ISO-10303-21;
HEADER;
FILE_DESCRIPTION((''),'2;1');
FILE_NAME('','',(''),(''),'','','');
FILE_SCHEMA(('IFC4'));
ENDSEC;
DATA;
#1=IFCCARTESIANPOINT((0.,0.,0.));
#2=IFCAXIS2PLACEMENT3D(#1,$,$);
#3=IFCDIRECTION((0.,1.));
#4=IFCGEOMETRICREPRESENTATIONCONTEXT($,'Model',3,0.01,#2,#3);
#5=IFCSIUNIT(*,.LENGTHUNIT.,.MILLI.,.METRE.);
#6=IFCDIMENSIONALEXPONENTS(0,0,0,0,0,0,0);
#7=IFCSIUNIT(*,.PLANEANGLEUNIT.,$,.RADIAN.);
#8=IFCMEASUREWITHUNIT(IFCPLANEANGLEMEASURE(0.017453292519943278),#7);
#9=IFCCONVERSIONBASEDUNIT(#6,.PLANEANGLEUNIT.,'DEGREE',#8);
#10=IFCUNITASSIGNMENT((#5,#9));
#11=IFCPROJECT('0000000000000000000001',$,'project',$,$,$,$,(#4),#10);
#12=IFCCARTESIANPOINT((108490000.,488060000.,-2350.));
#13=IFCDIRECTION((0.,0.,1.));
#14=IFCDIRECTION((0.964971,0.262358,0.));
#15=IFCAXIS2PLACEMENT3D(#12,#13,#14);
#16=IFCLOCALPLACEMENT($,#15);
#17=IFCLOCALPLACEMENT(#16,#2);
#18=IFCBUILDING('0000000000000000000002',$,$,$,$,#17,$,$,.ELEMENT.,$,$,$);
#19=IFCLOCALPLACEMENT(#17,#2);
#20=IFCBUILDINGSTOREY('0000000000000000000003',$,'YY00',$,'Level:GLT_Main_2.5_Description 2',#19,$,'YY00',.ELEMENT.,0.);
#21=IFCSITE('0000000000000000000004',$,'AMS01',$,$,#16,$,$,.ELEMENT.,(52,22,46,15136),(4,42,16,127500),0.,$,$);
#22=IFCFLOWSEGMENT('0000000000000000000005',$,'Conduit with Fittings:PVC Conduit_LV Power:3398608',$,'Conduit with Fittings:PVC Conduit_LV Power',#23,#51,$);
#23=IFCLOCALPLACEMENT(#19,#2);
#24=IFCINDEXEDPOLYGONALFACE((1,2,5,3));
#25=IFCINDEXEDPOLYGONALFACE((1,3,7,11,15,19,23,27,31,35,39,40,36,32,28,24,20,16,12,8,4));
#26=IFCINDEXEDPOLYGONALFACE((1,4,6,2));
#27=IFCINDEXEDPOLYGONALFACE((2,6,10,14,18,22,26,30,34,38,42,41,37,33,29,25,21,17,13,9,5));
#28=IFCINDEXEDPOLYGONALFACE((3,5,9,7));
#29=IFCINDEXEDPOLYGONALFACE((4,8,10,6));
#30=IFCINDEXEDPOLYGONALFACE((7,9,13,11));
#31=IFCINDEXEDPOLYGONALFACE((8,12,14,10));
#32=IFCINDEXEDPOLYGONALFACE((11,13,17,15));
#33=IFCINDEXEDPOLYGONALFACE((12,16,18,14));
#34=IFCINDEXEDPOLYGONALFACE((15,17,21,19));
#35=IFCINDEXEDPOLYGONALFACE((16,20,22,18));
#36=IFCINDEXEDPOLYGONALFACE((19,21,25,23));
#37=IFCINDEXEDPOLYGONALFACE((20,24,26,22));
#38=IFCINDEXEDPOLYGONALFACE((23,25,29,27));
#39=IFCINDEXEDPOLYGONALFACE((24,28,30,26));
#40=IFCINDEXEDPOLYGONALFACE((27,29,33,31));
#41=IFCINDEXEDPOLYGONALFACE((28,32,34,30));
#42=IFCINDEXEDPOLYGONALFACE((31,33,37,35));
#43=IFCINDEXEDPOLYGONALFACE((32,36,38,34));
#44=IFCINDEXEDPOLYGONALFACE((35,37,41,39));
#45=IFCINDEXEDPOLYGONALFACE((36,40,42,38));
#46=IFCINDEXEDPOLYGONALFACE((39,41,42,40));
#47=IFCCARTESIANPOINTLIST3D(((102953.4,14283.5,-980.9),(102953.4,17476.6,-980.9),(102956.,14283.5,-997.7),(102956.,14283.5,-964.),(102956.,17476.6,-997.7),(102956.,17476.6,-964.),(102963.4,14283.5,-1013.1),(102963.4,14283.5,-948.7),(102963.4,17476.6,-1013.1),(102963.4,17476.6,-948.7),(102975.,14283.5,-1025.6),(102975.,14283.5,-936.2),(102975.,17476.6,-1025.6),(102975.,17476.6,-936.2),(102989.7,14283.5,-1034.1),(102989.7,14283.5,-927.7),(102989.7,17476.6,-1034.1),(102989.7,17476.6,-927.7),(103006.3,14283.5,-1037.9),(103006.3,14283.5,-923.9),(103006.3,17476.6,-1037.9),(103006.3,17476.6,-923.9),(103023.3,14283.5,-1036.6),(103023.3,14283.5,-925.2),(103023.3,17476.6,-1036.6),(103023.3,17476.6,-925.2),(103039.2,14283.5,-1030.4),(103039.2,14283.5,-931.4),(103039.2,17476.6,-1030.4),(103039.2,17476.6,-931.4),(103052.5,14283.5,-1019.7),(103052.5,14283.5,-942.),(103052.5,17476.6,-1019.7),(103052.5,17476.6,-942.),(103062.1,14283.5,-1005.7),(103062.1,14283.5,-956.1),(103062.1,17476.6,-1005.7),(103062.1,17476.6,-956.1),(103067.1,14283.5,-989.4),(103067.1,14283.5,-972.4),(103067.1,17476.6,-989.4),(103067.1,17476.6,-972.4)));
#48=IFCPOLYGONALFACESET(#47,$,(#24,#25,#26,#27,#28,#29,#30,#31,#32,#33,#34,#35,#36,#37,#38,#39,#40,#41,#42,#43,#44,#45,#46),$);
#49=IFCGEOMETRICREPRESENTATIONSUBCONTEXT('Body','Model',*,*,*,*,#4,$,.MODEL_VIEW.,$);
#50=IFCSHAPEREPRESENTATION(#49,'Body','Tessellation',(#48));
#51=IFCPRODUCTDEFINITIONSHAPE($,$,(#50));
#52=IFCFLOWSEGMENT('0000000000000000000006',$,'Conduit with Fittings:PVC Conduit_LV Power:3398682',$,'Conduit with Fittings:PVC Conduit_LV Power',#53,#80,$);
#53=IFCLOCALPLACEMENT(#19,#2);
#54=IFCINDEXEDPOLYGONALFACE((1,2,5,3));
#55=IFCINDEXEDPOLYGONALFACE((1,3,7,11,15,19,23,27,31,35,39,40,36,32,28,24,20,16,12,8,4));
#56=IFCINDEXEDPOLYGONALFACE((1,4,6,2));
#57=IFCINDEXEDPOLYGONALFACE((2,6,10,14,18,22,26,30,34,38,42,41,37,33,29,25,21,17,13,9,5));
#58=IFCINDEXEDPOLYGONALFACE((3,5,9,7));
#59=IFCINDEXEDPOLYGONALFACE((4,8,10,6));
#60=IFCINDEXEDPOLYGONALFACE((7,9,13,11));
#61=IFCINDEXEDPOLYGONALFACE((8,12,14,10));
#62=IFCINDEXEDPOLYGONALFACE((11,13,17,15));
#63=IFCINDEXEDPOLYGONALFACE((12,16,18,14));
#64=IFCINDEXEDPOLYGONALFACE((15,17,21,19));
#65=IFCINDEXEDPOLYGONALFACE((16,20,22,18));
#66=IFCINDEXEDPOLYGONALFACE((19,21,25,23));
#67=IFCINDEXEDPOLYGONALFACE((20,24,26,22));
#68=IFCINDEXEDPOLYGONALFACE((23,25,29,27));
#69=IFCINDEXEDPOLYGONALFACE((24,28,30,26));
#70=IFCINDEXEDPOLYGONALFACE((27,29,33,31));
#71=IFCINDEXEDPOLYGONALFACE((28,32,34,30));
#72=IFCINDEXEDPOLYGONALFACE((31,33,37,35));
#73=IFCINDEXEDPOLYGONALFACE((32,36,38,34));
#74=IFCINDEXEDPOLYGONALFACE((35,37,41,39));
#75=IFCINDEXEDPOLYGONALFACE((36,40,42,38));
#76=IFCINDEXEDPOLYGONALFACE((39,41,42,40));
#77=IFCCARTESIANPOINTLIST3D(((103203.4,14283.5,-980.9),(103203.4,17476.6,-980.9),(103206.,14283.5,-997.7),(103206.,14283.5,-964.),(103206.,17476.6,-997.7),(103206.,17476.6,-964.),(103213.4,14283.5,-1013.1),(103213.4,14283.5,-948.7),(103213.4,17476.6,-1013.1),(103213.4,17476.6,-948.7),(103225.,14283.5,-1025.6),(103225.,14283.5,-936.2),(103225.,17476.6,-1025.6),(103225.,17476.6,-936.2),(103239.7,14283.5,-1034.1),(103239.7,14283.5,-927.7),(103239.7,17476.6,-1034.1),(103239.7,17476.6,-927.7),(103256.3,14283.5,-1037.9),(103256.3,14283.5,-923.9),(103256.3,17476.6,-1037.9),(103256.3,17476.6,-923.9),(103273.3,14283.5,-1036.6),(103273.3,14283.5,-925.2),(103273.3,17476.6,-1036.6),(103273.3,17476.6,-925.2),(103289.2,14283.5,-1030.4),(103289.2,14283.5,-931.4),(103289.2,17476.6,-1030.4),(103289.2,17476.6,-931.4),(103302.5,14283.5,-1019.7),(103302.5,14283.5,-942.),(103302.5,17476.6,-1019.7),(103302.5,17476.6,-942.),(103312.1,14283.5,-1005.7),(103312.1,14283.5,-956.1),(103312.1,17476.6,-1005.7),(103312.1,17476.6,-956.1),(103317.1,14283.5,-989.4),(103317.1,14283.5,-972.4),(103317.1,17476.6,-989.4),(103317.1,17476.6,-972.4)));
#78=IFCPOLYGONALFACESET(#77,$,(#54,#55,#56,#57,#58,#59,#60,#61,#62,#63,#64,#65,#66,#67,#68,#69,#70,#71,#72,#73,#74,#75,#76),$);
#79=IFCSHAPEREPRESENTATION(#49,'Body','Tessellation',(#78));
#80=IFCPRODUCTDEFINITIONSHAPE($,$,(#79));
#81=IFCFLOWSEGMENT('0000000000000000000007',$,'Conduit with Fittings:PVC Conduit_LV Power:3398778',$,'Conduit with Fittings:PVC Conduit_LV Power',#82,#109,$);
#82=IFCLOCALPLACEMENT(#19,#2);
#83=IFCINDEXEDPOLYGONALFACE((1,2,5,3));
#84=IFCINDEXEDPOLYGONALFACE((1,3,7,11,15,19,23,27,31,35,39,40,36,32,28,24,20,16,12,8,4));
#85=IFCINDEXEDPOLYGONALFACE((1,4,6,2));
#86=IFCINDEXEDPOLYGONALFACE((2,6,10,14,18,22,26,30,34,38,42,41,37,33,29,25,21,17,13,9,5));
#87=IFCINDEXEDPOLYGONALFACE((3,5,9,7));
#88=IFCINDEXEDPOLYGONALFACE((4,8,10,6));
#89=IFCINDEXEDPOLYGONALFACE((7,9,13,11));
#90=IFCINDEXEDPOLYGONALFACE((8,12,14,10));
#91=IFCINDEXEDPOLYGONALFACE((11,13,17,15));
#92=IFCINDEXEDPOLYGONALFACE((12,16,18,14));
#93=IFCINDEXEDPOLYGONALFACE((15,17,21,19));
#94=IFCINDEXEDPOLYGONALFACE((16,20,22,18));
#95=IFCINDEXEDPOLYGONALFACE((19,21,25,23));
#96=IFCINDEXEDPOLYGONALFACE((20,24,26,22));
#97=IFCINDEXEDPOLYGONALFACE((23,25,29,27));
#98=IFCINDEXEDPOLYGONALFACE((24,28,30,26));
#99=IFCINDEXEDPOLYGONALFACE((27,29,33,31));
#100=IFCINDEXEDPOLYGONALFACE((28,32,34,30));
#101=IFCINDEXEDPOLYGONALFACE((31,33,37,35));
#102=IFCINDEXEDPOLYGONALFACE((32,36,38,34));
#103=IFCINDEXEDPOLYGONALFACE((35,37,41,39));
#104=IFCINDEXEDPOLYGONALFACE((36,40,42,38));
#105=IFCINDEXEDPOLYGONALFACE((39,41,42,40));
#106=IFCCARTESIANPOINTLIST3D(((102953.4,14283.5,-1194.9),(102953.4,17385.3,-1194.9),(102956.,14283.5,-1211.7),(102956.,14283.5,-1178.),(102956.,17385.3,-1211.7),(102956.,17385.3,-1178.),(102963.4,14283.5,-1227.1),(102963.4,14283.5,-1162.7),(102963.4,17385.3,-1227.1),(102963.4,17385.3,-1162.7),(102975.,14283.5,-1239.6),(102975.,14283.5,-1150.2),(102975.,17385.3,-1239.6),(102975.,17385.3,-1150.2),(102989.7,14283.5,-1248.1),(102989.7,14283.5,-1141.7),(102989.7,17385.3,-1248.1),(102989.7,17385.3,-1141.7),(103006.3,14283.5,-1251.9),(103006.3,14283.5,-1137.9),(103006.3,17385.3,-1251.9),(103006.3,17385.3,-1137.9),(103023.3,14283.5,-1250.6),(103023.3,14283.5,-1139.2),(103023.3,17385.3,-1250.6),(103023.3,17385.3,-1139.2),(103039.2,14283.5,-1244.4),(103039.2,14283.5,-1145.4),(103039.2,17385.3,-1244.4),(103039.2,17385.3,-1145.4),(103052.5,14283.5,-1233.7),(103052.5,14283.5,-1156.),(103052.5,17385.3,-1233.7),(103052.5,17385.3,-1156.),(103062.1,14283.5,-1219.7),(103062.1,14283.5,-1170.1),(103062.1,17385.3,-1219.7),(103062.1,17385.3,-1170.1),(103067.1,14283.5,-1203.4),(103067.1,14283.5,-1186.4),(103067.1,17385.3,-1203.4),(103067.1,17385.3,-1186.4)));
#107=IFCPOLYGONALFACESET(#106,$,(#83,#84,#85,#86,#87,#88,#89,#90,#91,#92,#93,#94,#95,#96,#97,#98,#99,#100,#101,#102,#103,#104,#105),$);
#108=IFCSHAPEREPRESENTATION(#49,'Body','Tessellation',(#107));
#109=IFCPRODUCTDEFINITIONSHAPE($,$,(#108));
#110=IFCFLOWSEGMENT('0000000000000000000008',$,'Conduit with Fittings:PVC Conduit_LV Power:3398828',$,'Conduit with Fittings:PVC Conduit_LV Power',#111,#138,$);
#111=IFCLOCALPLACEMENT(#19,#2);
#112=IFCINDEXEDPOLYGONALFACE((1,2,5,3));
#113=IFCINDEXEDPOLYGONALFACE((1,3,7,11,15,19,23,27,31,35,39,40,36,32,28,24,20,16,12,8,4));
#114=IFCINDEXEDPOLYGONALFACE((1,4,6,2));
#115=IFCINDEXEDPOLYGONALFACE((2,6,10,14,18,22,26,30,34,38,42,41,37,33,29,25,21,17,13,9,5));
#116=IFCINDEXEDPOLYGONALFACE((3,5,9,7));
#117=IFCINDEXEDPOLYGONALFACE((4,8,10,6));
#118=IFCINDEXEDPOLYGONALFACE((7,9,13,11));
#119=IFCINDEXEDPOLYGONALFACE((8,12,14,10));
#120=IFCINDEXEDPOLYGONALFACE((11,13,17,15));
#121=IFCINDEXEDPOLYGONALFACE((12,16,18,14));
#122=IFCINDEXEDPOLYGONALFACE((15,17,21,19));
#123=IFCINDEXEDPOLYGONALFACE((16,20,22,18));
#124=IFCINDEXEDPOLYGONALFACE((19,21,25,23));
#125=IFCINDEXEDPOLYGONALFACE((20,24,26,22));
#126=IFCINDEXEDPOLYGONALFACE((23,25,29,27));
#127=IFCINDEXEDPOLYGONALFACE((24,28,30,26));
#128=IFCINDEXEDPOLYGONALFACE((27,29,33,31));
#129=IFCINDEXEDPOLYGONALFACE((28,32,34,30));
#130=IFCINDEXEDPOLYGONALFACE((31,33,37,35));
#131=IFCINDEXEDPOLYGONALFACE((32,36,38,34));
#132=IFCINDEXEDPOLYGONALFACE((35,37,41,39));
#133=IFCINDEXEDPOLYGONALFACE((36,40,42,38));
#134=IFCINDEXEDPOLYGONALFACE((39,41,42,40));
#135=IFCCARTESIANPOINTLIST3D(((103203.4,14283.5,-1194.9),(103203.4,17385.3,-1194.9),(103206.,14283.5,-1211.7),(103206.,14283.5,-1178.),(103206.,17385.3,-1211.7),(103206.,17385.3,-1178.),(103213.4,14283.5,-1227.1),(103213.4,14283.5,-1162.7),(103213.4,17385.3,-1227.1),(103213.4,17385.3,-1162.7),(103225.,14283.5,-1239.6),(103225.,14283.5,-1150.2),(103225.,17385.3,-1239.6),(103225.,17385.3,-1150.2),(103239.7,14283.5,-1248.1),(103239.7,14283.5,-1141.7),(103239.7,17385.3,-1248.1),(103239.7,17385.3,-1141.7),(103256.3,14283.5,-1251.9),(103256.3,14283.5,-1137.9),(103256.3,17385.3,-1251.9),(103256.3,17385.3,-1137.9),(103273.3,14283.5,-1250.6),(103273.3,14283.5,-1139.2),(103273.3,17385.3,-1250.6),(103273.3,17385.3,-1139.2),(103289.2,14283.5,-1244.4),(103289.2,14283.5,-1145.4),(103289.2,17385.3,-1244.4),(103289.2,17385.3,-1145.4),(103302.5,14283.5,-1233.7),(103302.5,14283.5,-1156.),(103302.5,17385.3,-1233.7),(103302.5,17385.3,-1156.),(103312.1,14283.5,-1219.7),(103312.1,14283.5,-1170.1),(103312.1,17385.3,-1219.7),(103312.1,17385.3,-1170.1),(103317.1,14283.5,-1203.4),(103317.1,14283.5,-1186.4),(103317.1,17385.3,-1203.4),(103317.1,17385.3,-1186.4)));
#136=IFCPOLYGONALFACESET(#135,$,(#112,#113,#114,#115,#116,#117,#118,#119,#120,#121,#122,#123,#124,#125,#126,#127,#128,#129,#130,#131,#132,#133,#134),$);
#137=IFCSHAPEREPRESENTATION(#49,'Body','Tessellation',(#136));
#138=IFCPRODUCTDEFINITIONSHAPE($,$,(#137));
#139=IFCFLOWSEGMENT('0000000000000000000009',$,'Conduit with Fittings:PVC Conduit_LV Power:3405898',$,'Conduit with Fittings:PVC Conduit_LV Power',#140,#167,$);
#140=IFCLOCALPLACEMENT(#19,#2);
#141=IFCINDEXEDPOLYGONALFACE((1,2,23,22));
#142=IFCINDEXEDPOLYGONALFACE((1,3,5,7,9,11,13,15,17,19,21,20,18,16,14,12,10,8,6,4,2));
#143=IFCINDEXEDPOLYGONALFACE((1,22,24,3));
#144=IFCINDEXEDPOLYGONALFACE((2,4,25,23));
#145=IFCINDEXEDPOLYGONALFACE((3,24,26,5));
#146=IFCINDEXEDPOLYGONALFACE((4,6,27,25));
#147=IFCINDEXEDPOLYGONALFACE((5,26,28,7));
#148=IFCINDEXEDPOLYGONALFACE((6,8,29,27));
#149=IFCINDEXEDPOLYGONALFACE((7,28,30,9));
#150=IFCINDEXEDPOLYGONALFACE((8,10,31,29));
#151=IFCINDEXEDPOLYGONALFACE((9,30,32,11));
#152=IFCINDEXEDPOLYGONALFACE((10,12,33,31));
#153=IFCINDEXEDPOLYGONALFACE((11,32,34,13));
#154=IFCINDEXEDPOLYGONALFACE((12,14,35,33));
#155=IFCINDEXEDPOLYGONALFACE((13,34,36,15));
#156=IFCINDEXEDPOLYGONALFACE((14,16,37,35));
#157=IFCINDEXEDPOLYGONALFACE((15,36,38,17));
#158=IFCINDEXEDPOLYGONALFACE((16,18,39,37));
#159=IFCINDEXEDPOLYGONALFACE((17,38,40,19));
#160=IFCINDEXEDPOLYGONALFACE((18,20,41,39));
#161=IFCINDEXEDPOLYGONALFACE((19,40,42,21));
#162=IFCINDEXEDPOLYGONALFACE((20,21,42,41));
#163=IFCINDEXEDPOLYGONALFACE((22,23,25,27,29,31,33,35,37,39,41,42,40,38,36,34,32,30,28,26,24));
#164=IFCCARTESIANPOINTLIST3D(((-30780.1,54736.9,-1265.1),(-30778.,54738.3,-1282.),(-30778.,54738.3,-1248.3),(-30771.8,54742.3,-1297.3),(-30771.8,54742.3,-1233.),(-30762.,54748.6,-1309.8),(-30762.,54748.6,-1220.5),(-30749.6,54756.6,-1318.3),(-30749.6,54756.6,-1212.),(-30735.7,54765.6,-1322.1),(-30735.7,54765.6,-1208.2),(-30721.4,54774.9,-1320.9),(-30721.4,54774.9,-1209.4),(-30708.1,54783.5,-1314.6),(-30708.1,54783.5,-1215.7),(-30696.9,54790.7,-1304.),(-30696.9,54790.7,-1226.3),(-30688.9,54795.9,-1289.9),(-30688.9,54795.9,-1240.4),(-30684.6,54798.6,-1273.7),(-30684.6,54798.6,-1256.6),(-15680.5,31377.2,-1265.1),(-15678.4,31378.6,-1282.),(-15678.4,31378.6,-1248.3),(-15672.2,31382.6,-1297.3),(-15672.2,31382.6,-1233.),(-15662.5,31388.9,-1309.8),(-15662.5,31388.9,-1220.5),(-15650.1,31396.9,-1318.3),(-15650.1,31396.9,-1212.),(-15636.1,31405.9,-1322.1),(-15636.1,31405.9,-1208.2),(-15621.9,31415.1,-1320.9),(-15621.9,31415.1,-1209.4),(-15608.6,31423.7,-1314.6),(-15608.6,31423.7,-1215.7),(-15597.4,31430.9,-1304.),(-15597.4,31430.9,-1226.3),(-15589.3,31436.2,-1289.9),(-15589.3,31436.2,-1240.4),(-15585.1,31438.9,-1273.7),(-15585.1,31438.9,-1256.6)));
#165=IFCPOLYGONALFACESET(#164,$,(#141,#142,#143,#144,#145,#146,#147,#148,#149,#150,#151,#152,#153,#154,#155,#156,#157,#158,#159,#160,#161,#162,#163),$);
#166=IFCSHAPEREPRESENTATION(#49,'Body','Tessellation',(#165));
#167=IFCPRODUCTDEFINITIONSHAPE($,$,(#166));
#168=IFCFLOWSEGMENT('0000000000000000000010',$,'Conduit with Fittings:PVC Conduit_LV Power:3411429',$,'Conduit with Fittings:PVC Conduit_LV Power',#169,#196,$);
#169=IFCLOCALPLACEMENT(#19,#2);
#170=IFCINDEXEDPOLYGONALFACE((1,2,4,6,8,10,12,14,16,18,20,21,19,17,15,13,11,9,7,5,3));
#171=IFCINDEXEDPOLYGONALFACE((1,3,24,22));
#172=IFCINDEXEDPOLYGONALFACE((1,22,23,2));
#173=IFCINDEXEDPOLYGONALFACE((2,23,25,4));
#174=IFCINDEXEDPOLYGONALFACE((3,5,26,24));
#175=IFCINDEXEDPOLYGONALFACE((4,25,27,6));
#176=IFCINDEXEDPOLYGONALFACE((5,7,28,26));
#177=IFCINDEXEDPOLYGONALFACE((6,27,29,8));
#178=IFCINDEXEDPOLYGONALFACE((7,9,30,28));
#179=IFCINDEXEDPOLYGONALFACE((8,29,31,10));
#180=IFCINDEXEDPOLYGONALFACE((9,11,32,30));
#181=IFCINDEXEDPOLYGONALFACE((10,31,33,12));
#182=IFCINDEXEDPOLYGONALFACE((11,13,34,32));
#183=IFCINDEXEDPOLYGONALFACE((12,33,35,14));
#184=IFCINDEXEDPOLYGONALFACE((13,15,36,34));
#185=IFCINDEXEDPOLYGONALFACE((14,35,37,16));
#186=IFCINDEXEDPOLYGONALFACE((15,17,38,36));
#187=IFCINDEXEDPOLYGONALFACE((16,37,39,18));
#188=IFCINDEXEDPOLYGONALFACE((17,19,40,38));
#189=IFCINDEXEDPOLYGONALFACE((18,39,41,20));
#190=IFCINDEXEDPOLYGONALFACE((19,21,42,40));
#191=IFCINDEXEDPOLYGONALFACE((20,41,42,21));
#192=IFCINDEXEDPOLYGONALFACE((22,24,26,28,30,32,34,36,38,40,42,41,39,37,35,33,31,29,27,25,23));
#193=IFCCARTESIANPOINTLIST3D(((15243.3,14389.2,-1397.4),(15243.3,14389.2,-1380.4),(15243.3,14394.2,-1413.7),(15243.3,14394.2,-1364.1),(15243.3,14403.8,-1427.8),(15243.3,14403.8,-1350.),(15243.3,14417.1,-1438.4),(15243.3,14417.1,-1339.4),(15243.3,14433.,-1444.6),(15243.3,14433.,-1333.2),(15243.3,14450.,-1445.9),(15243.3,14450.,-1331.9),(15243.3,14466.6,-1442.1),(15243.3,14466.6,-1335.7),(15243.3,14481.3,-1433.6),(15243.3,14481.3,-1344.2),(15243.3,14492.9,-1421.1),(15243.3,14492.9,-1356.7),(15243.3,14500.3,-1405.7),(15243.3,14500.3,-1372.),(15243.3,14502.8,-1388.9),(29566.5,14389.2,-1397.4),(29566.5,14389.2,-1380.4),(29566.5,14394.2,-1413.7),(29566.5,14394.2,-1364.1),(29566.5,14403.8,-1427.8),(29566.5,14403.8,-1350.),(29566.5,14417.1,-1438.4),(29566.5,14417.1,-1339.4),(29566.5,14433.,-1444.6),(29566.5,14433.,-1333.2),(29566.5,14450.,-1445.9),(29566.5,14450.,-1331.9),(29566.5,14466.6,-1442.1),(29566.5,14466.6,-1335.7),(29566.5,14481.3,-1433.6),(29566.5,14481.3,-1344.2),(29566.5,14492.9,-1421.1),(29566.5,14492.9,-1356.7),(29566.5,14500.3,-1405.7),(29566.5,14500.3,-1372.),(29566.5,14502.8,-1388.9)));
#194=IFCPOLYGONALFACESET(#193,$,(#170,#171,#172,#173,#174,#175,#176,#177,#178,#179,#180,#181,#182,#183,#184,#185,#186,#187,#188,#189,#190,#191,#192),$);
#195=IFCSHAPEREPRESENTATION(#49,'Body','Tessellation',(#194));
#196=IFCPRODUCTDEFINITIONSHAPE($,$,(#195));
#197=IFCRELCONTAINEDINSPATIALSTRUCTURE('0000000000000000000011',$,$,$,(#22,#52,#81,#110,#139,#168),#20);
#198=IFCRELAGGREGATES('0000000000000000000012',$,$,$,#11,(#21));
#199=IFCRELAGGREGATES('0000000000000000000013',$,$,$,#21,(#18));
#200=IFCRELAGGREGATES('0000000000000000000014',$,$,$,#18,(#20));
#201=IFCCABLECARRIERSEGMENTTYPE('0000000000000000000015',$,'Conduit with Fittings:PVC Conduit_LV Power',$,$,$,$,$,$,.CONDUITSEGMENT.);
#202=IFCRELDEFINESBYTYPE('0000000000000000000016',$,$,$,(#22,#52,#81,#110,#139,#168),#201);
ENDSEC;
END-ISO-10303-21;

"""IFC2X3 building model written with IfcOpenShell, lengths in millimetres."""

from ifc_helpers import new_model, entity, si_unit, converted_unit, direction, frame, frame_2d, origin, place, context, subcontext, project, spatial, circle, extrude, type_object, element, save


model = new_model("IFC2X3")

# Units and contexts
model_context = context("Model", 3, precision=0.01, world=origin(), true_north=direction((0.0, 1.0)))
body_context = subcontext(model_context, "Body", "Model", "MODEL_VIEW")
ifc_project = project(units=[si_unit("LENGTHUNIT", "METRE", prefix="MILLI"), converted_unit("PLANEANGLEUNIT", "DEGREE", entity("IfcPlaneAngleMeasure", 0.017453292519943278), si_unit("PLANEANGLEUNIT", "RADIAN"), dimensions=[0, 0, 0, 0, 0, 0, 0])], contexts=[model_context])

# Site, building, storey
site_placement = place(None, frame((108490000.0, 488060000.0, -2350.0), z_axis=(0.0, 0.0, 1.0), x_axis=(0.964971, 0.262358, 0.0)))
site = spatial("IfcSite", under=ifc_project, at=site_placement, Name="AMS01", CompositionType="ELEMENT", RefLatitude=(52, 22, 46, 15136), RefLongitude=(4, 42, 16, 127500), RefElevation=0.0)
building_placement = place(site_placement, origin())
building = spatial("IfcBuilding", under=site, at=building_placement, CompositionType="ELEMENT")
storey_placement = place(building_placement, origin())
storey = spatial("IfcBuildingStorey", under=building, at=storey_placement, Name="YY00", ObjectType="Level:GLT_Main_2.5_Description 2", LongName="YY00", CompositionType="ELEMENT", Elevation=0.0)

# Flow segments
cable_carrier_segment_type = type_object("IfcCableCarrierSegmentType", Name="Conduit with Fittings:PVC Conduit_LV Power", PredefinedType="CONDUITSEGMENT")
flow_segment_1_placement = place(storey_placement, origin())
element("IfcFlowSegment", 1, at=flow_segment_1_placement, inside=storey, type_object=cable_carrier_segment_type, Name="Conduit with Fittings:PVC Conduit_LV Power:3398608", ObjectType="Conduit with Fittings:PVC Conduit_LV Power", context=body_context, shape_type="SweptSolid", body=[
    extrude(circle(Radius=57.2, at=frame_2d((0.0, 0.0), x_axis=(1.0, 0.0))), frame((103010.6, 14283.5, -980.9), z_axis=(0.0, 1.0, 0.0), x_axis=(-1.0, 0.0, 0.0)), (0.0, 0.0, 1.0), 3193.1),
])
flow_segment_2_placement = place(storey_placement, origin())
element("IfcFlowSegment", 2, at=flow_segment_2_placement, inside=storey, type_object=cable_carrier_segment_type, Name="Conduit with Fittings:PVC Conduit_LV Power:3398682", ObjectType="Conduit with Fittings:PVC Conduit_LV Power", context=body_context, shape_type="SweptSolid", body=[
    extrude(circle(Radius=57.2, at=frame_2d((0.0, 0.0), x_axis=(1.0, 0.0))), frame((103260.6, 14283.5, -980.9), z_axis=(0.0, 1.0, 0.0), x_axis=(-1.0, 0.0, 0.0)), (0.0, 0.0, 1.0), 3193.1),
])
flow_segment_3_placement = place(storey_placement, origin())
element("IfcFlowSegment", 3, at=flow_segment_3_placement, inside=storey, type_object=cable_carrier_segment_type, Name="Conduit with Fittings:PVC Conduit_LV Power:3398778", ObjectType="Conduit with Fittings:PVC Conduit_LV Power", context=body_context, shape_type="SweptSolid", body=[
    extrude(circle(Radius=57.2, at=frame_2d((0.0, 0.0), x_axis=(1.0, 0.0))), frame((103010.6, 14283.5, -1194.9), z_axis=(0.0, 1.0, 0.0), x_axis=(-1.0, 0.0, 0.0)), (0.0, 0.0, 1.0), 3101.8),
])
flow_segment_4_placement = place(storey_placement, origin())
element("IfcFlowSegment", 4, at=flow_segment_4_placement, inside=storey, type_object=cable_carrier_segment_type, Name="Conduit with Fittings:PVC Conduit_LV Power:3398828", ObjectType="Conduit with Fittings:PVC Conduit_LV Power", context=body_context, shape_type="SweptSolid", body=[
    extrude(circle(Radius=57.2, at=frame_2d((0.0, 0.0), x_axis=(1.0, 0.0))), frame((103260.6, 14283.5, -1194.9), z_axis=(0.0, 1.0, 0.0), x_axis=(-1.0, 0.0, 0.0)), (0.0, 0.0, 1.0), 3101.8),
])
flow_segment_5_placement = place(storey_placement, origin())
element("IfcFlowSegment", 5, at=flow_segment_5_placement, inside=storey, type_object=cable_carrier_segment_type, Name="Conduit with Fittings:PVC Conduit_LV Power:3405898", ObjectType="Conduit with Fittings:PVC Conduit_LV Power", context=body_context, shape_type="SweptSolid", body=[
    extrude(circle(Radius=57.2, at=frame_2d((0.0, 0.0), x_axis=(1.0, 0.0))), frame((-15632.6, 31408.2, -1265.1), z_axis=(-0.542856, 0.839826, 0.0), x_axis=(-0.839826, -0.542856, 0.0)), (0.0, 0.0, 1.0), 27815.0),
])
flow_segment_6_placement = place(storey_placement, origin())
element("IfcFlowSegment", 6, at=flow_segment_6_placement, inside=storey, type_object=cable_carrier_segment_type, Name="Conduit with Fittings:PVC Conduit_LV Power:3411429", ObjectType="Conduit with Fittings:PVC Conduit_LV Power", context=body_context, shape_type="SweptSolid", body=[
    extrude(circle(Radius=57.2, at=frame_2d((0.0, 0.0), x_axis=(1.0, 0.0))), frame((15243.3, 14445.7, -1388.9), z_axis=(1.0, 0.0, 0.0), x_axis=(0.0, 1.0, 0.0)), (0.0, 0.0, 1.0), 14323.1),
])

save(model, "model.ifc")
